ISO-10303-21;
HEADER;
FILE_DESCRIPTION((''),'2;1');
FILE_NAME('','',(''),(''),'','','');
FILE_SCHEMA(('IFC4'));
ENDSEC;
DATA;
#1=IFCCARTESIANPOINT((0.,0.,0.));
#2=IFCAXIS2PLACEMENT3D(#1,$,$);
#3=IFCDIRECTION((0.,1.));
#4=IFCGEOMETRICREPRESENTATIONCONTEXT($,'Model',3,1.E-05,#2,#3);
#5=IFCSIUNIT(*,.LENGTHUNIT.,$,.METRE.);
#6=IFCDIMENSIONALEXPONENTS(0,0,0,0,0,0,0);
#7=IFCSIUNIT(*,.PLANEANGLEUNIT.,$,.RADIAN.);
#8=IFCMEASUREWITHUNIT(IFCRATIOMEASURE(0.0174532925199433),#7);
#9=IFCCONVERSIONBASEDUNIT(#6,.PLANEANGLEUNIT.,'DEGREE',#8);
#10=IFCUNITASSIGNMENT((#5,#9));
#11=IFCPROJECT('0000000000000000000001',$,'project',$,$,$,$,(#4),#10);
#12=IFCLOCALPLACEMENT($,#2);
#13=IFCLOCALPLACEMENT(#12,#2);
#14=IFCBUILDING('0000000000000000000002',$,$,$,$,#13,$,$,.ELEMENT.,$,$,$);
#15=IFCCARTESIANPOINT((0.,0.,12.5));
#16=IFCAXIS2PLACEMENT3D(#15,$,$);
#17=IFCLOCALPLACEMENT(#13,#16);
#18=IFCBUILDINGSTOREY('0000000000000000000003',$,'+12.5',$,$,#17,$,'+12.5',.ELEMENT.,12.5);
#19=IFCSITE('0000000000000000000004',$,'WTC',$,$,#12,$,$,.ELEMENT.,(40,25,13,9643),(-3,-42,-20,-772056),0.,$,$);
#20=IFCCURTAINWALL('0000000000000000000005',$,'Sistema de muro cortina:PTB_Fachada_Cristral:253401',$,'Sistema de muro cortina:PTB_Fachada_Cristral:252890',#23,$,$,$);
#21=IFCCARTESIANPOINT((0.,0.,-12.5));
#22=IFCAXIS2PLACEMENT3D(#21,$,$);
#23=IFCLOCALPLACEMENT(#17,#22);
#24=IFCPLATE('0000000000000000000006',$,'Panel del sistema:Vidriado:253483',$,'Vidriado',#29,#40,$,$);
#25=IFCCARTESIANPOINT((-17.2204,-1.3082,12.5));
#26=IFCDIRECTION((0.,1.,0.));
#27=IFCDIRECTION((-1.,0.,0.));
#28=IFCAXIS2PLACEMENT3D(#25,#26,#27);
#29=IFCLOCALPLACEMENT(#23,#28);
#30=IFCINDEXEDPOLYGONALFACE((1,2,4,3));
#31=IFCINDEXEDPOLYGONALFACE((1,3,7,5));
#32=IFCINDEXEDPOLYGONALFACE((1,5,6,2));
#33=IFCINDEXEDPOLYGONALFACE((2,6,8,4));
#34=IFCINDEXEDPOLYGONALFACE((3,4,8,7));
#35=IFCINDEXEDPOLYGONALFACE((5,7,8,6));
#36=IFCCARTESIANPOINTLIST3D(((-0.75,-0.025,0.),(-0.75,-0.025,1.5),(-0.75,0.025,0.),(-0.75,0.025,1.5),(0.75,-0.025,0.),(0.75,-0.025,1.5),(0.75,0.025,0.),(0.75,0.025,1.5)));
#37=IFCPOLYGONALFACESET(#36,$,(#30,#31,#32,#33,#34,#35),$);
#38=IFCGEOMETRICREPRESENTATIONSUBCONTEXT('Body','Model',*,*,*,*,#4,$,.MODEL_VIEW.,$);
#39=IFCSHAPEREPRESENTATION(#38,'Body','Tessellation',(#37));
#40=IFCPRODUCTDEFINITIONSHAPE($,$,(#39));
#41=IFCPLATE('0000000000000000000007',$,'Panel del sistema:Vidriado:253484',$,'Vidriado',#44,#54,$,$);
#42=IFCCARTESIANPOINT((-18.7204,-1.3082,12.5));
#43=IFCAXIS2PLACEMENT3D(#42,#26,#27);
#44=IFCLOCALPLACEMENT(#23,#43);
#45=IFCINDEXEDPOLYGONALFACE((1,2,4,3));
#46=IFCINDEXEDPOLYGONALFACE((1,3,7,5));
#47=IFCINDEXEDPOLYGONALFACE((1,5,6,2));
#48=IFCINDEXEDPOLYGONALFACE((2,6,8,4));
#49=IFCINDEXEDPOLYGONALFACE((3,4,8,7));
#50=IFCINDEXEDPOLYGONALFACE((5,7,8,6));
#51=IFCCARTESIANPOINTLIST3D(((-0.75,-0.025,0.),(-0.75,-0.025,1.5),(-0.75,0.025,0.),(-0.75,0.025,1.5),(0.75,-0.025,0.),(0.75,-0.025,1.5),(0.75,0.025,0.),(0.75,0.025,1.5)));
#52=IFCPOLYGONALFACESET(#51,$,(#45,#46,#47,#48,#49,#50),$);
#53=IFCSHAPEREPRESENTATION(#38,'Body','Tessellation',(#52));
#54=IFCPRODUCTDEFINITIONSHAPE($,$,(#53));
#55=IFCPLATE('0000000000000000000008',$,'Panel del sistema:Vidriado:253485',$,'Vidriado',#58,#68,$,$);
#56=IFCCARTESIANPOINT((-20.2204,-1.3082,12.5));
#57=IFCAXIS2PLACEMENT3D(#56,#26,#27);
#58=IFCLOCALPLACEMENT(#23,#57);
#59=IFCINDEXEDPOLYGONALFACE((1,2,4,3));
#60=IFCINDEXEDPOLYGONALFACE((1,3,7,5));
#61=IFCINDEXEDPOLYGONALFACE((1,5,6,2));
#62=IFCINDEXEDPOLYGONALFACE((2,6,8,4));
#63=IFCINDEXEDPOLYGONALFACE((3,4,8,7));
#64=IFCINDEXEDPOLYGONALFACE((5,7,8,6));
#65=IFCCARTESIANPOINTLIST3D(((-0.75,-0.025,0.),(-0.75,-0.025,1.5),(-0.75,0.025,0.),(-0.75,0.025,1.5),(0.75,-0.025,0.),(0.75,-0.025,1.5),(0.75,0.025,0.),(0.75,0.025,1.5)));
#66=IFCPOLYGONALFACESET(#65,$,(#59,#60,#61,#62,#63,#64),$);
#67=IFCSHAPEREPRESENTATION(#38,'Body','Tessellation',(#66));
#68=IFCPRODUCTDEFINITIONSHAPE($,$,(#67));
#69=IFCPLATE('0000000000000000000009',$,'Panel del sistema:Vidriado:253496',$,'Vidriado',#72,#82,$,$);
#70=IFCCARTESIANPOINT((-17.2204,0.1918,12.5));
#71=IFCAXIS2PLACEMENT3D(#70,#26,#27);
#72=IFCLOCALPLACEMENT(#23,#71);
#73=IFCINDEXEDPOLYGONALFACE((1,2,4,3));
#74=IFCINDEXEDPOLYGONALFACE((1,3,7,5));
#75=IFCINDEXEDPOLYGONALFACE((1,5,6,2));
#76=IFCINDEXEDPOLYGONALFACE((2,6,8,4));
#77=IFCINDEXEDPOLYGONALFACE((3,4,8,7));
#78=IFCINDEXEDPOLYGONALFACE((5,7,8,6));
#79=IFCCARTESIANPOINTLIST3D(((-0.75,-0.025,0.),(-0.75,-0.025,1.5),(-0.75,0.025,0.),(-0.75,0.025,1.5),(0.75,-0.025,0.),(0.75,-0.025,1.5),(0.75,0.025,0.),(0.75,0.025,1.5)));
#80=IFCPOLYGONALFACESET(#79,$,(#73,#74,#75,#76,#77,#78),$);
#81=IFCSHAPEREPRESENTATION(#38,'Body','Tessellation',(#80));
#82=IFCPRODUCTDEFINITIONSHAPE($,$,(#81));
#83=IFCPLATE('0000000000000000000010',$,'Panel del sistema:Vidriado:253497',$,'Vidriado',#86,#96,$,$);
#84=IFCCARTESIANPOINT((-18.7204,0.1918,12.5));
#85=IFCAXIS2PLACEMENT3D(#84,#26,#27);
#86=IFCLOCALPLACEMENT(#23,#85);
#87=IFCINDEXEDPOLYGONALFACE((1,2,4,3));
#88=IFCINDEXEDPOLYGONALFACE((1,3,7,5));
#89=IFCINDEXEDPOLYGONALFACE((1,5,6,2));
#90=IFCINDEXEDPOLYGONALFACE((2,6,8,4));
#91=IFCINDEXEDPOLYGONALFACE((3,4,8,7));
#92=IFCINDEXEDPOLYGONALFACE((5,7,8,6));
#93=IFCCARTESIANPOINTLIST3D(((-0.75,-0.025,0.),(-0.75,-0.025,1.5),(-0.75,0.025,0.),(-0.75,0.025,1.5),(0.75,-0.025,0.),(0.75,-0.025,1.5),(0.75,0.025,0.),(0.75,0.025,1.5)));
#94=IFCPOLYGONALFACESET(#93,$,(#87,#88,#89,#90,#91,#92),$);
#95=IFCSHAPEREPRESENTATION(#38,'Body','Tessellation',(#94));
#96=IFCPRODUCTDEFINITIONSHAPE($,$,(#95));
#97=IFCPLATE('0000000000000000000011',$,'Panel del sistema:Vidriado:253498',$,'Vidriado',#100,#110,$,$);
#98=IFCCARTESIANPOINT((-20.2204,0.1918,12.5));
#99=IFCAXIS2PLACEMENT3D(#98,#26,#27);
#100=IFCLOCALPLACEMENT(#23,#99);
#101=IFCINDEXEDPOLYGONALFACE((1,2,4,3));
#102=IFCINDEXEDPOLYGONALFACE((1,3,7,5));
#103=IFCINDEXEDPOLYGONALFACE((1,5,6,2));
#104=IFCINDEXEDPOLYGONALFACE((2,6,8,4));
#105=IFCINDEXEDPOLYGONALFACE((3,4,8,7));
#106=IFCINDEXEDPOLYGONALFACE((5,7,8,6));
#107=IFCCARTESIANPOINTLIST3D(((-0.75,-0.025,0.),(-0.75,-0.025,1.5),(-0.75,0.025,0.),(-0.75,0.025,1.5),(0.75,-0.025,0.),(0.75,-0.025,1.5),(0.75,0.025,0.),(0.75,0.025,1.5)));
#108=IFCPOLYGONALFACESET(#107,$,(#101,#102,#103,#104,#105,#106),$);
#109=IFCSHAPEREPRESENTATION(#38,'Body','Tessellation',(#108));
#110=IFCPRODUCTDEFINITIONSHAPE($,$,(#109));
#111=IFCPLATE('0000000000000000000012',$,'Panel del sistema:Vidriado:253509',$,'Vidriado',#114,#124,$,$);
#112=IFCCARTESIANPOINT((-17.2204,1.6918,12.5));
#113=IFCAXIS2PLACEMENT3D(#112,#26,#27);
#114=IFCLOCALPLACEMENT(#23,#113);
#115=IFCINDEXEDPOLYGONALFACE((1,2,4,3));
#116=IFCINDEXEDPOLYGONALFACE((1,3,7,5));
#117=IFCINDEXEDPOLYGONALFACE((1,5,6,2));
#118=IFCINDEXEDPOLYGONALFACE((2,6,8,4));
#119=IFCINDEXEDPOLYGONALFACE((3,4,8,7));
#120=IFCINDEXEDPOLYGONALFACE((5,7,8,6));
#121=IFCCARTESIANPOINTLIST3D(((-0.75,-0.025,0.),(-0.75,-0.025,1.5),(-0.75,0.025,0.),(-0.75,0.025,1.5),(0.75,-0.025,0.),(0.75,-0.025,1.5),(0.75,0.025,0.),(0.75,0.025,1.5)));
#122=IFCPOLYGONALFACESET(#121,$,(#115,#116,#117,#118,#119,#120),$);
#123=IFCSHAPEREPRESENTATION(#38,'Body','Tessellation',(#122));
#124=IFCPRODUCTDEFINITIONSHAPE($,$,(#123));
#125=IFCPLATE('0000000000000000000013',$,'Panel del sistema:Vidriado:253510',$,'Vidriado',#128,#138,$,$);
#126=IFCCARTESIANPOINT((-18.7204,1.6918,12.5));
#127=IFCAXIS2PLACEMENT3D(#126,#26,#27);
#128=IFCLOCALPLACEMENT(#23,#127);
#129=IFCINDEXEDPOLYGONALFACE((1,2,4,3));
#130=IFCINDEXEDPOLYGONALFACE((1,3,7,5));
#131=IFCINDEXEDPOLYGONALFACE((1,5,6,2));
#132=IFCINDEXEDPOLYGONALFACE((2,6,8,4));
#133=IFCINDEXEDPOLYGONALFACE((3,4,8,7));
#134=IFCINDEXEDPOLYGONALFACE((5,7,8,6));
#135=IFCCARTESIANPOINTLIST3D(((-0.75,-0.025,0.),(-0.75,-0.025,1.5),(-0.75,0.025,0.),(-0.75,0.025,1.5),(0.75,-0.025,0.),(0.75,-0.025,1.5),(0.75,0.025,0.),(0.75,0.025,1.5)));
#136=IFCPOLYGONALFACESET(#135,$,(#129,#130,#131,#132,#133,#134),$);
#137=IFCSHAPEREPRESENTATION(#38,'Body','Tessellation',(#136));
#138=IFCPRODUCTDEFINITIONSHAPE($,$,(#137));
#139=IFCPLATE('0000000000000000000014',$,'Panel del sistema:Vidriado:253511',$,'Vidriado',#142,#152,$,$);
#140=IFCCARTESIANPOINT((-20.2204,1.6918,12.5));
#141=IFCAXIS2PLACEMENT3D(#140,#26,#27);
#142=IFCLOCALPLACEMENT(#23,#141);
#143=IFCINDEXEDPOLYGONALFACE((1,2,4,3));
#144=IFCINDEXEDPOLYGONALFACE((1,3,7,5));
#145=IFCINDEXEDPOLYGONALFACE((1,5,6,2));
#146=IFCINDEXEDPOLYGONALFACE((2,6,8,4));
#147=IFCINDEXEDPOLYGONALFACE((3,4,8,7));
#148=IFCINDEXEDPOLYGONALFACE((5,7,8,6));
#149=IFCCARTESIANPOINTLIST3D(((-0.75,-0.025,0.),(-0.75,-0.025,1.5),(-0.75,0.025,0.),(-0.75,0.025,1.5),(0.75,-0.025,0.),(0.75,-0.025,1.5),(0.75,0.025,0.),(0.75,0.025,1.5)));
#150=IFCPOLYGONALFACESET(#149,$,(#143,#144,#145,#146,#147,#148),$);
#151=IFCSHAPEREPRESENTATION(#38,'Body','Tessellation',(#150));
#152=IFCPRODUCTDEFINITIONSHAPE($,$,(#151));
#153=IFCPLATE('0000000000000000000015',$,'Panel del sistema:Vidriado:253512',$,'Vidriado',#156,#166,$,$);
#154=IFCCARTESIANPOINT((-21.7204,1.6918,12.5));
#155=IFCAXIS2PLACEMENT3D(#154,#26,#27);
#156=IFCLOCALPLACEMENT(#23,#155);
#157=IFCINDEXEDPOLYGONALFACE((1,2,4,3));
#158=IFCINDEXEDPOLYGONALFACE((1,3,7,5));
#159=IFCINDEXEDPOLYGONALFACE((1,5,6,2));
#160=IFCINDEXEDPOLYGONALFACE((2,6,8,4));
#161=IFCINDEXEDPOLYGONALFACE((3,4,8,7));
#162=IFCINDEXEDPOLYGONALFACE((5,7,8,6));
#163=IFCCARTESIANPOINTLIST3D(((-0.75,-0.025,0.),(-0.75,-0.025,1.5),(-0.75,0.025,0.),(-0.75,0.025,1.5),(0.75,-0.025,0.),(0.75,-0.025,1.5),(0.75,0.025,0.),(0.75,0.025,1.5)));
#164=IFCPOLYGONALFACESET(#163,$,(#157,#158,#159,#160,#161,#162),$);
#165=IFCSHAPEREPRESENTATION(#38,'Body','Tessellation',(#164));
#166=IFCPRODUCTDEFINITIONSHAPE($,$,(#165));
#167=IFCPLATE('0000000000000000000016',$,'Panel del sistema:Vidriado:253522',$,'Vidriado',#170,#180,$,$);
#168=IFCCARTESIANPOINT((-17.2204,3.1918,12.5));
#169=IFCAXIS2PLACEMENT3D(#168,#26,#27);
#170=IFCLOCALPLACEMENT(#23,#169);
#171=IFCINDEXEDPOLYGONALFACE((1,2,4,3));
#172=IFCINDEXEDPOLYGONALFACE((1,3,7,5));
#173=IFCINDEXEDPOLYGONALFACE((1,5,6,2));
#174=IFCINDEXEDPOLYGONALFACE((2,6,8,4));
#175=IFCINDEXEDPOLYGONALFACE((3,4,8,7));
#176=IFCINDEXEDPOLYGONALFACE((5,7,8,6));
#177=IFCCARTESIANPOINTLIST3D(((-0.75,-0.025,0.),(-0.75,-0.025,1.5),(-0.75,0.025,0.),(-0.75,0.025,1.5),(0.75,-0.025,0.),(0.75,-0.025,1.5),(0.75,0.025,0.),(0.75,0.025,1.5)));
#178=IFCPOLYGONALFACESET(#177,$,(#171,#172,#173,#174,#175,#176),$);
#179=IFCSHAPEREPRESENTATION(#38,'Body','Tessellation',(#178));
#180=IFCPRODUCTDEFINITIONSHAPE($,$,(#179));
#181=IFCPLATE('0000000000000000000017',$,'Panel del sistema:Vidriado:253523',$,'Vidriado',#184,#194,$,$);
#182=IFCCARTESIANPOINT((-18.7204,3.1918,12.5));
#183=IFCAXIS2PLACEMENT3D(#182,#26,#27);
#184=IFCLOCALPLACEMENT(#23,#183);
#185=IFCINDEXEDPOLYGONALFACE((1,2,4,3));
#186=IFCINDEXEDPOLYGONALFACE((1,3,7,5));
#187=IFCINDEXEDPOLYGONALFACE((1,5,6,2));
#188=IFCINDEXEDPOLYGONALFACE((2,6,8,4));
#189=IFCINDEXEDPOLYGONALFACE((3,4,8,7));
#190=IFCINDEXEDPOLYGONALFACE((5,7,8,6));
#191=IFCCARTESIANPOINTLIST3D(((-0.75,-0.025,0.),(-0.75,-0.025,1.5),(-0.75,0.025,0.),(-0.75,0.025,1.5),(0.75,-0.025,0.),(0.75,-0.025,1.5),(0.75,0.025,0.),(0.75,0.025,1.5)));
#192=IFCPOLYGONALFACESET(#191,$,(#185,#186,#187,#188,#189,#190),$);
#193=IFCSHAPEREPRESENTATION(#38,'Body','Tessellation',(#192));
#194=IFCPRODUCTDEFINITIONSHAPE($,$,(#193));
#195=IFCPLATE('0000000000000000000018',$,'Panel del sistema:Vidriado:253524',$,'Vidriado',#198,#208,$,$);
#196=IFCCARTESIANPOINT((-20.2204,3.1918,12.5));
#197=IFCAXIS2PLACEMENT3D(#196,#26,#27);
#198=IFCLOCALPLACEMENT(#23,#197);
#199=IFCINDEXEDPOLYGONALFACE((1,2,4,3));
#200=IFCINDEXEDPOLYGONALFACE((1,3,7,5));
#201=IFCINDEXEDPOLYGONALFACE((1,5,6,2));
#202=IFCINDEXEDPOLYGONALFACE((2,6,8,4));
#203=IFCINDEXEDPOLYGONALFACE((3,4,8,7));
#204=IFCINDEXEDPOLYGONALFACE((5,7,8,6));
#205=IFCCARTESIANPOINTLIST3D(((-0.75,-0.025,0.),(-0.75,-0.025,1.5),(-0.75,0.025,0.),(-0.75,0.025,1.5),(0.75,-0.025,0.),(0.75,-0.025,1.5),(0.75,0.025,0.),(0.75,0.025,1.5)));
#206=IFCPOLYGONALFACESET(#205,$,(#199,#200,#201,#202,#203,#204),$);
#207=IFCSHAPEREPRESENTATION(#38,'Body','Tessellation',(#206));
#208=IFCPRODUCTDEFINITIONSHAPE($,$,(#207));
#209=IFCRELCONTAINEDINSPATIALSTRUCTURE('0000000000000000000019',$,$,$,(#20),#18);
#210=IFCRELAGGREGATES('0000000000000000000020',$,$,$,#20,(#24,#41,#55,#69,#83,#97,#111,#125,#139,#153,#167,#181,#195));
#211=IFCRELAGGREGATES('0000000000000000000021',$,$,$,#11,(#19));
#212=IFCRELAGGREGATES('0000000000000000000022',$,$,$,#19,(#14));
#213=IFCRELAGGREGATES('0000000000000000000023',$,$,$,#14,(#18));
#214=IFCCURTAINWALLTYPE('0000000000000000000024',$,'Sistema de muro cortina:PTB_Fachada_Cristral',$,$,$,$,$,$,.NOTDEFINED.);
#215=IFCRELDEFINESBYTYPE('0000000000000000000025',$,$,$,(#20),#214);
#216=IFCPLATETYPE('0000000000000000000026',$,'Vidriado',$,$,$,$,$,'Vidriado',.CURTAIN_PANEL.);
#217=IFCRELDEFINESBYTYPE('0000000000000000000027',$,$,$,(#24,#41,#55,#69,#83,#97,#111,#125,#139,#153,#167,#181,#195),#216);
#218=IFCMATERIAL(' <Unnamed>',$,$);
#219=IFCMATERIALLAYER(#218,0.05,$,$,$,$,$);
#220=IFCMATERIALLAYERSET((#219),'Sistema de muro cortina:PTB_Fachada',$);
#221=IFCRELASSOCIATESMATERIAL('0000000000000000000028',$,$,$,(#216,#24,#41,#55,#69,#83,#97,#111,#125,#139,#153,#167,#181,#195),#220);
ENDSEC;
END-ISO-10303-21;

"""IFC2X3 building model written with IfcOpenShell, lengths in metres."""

from ifc_helpers import new_model, entity, si_unit, converted_unit, direction, frame, origin, origin_2d_with_axis, place, context, subcontext, project, spatial, rectangle, extrude, source, transform, mapped, material, layer, layer_set, layer_usage, type_object, type_shapes, element, aggregate, save


model = new_model("IFC2X3")

# Units and contexts
model_context = context("Model", 3, precision=1e-05, world=origin(), true_north=direction((0.0, 1.0)))
body_context = subcontext(model_context, "Body", "Model", "MODEL_VIEW")
ifc_project = project(units=[si_unit("LENGTHUNIT", "METRE"), converted_unit("PLANEANGLEUNIT", "DEGREE", entity("IfcRatioMeasure", 0.0174532925199433), si_unit("PLANEANGLEUNIT", "RADIAN"), dimensions=[0, 0, 0, 0, 0, 0, 0])], contexts=[model_context])

# Site, building, storey
site_placement = place(None, origin())
site = spatial("IfcSite", under=ifc_project, at=site_placement, Name="WTC", CompositionType="ELEMENT", RefLatitude=(40, 25, 13, 9643), RefLongitude=(-3, -42, -20, -772056), RefElevation=0.0)
building_placement = place(site_placement, origin())
building = spatial("IfcBuilding", under=site, at=building_placement, CompositionType="ELEMENT")
storey_placement = place(building_placement, frame((0.0, 0.0, 12.5)))
storey = spatial("IfcBuildingStorey", under=building, at=storey_placement, Name="+12.5", LongName="+12.5", CompositionType="ELEMENT", Elevation=12.5)

# Curtain wall, plates
curtain_wall_type = type_object("IfcCurtainWallType", Name="Sistema de muro cortina:PTB_Fachada_Cristral", PredefinedType="NOTDEFINED")
curtain_wall_placement = place(storey_placement, frame((0.0, 0.0, -12.5)))
curtain_wall = element("IfcCurtainWall", 1, at=curtain_wall_placement, inside=storey, type_object=curtain_wall_type, Name="Sistema de muro cortina:PTB_Fachada_Cristral:253401", ObjectType="Sistema de muro cortina:PTB_Fachada_Cristral:252890")
ifc_material = material(Name=" <Unnamed>")
ifc_layer = layer(ifc_material, 0.05)
ifc_layer_set = layer_set([ifc_layer], Name="Sistema de muro cortina:PTB_Fachada")
ifc_layer_usage_1 = layer_usage(ifc_layer_set, "AXIS3", "POSITIVE", 0.0)
plate_type_1 = type_object("IfcPlateType", Name="Vidriado", ElementType="Vidriado", PredefinedType="CURTAIN_PANEL", material=ifc_layer_set)
shared_shape_1 = source(origin(), body_context, "Body", "SweptSolid", [
    extrude(rectangle(XDim=0.05, YDim=1.5, at=origin_2d_with_axis()), frame((0.0, 0.0, 0.0), z_axis=(0.0, 0.0, 1.0), x_axis=(0.0, 1.0, 0.0)), (0.0, 0.0, 1.0), 1.5),
])
type_shapes(plate_type_1, [shared_shape_1])
plate_1_placement = place(curtain_wall_placement, frame((-17.2204, -1.3082, 12.5), z_axis=(0.0, 1.0, 0.0), x_axis=(-1.0, 0.0, 0.0)))
plate_1 = element("IfcPlate", 2, at=plate_1_placement, type_object=plate_type_1, material=ifc_layer_usage_1, Name="Panel del sistema:Vidriado:253483", ObjectType="Vidriado", context=body_context, shape_type="MappedRepresentation", body=[
    mapped(shared_shape_1, transform((0.0, 0.0, 0.0), scale=1.0)),
])
ifc_layer_usage_2 = layer_usage(ifc_layer_set, "AXIS3", "POSITIVE", 0.0)
plate_2_placement = place(curtain_wall_placement, frame((-18.7204, -1.3082, 12.5), z_axis=(0.0, 1.0, 0.0), x_axis=(-1.0, 0.0, 0.0)))
plate_2 = element("IfcPlate", 3, at=plate_2_placement, type_object=plate_type_1, material=ifc_layer_usage_2, Name="Panel del sistema:Vidriado:253484", ObjectType="Vidriado", context=body_context, shape_type="MappedRepresentation", body=[
    mapped(shared_shape_1, transform((0.0, 0.0, 0.0), scale=1.0)),
])
ifc_layer_usage_3 = layer_usage(ifc_layer_set, "AXIS3", "POSITIVE", 0.0)
plate_3_placement = place(curtain_wall_placement, frame((-20.2204, -1.3082, 12.5), z_axis=(0.0, 1.0, 0.0), x_axis=(-1.0, 0.0, 0.0)))
plate_3 = element("IfcPlate", 4, at=plate_3_placement, type_object=plate_type_1, material=ifc_layer_usage_3, Name="Panel del sistema:Vidriado:253485", ObjectType="Vidriado", context=body_context, shape_type="MappedRepresentation", body=[
    mapped(shared_shape_1, transform((0.0, 0.0, 0.0), scale=1.0)),
])
ifc_layer_usage_4 = layer_usage(ifc_layer_set, "AXIS3", "POSITIVE", 0.0)
plate_4_placement = place(curtain_wall_placement, frame((-17.2204, 0.1918, 12.5), z_axis=(0.0, 1.0, 0.0), x_axis=(-1.0, 0.0, 0.0)))
plate_4 = element("IfcPlate", 5, at=plate_4_placement, type_object=plate_type_1, material=ifc_layer_usage_4, Name="Panel del sistema:Vidriado:253496", ObjectType="Vidriado", context=body_context, shape_type="MappedRepresentation", body=[
    mapped(shared_shape_1, transform((0.0, 0.0, 0.0), scale=1.0)),
])
ifc_layer_usage_5 = layer_usage(ifc_layer_set, "AXIS3", "POSITIVE", 0.0)
plate_5_placement = place(curtain_wall_placement, frame((-18.7204, 0.1918, 12.5), z_axis=(0.0, 1.0, 0.0), x_axis=(-1.0, 0.0, 0.0)))
plate_5 = element("IfcPlate", 6, at=plate_5_placement, type_object=plate_type_1, material=ifc_layer_usage_5, Name="Panel del sistema:Vidriado:253497", ObjectType="Vidriado", context=body_context, shape_type="MappedRepresentation", body=[
    mapped(shared_shape_1, transform((0.0, 0.0, 0.0), scale=1.0)),
])
ifc_layer_usage_6 = layer_usage(ifc_layer_set, "AXIS3", "POSITIVE", 0.0)
plate_6_placement = place(curtain_wall_placement, frame((-20.2204, 0.1918, 12.5), z_axis=(0.0, 1.0, 0.0), x_axis=(-1.0, 0.0, 0.0)))
plate_6 = element("IfcPlate", 7, at=plate_6_placement, type_object=plate_type_1, material=ifc_layer_usage_6, Name="Panel del sistema:Vidriado:253498", ObjectType="Vidriado", context=body_context, shape_type="MappedRepresentation", body=[
    mapped(shared_shape_1, transform((0.0, 0.0, 0.0), scale=1.0)),
])
ifc_layer_usage_7 = layer_usage(ifc_layer_set, "AXIS3", "POSITIVE", 0.0)
plate_7_placement = place(curtain_wall_placement, frame((-17.2204, 1.6918, 12.5), z_axis=(0.0, 1.0, 0.0), x_axis=(-1.0, 0.0, 0.0)))
plate_7 = element("IfcPlate", 8, at=plate_7_placement, type_object=plate_type_1, material=ifc_layer_usage_7, Name="Panel del sistema:Vidriado:253509", ObjectType="Vidriado", context=body_context, shape_type="MappedRepresentation", body=[
    mapped(shared_shape_1, transform((0.0, 0.0, 0.0), scale=1.0)),
])
ifc_layer_usage_8 = layer_usage(ifc_layer_set, "AXIS3", "POSITIVE", 0.0)
plate_8_placement = place(curtain_wall_placement, frame((-18.7204, 1.6918, 12.5), z_axis=(0.0, 1.0, 0.0), x_axis=(-1.0, 0.0, 0.0)))
plate_8 = element("IfcPlate", 9, at=plate_8_placement, type_object=plate_type_1, material=ifc_layer_usage_8, Name="Panel del sistema:Vidriado:253510", ObjectType="Vidriado", context=body_context, shape_type="MappedRepresentation", body=[
    mapped(shared_shape_1, transform((0.0, 0.0, 0.0), scale=1.0)),
])
ifc_layer_usage_9 = layer_usage(ifc_layer_set, "AXIS3", "POSITIVE", 0.0)
plate_9_placement = place(curtain_wall_placement, frame((-20.2204, 1.6918, 12.5), z_axis=(0.0, 1.0, 0.0), x_axis=(-1.0, 0.0, 0.0)))
plate_9 = element("IfcPlate", 10, at=plate_9_placement, type_object=plate_type_1, material=ifc_layer_usage_9, Name="Panel del sistema:Vidriado:253511", ObjectType="Vidriado", context=body_context, shape_type="MappedRepresentation", body=[
    mapped(shared_shape_1, transform((0.0, 0.0, 0.0), scale=1.0)),
])
ifc_layer_usage_10 = layer_usage(ifc_layer_set, "AXIS3", "POSITIVE", 0.0)
plate_10_placement = place(curtain_wall_placement, frame((-21.7204, 1.6918, 12.5), z_axis=(0.0, 1.0, 0.0), x_axis=(-1.0, 0.0, 0.0)))
plate_10 = element("IfcPlate", 11, at=plate_10_placement, type_object=plate_type_1, material=ifc_layer_usage_10, Name="Panel del sistema:Vidriado:253512", ObjectType="Vidriado", context=body_context, shape_type="MappedRepresentation", body=[
    mapped(shared_shape_1, transform((0.0, 0.0, 0.0), scale=1.0)),
])
ifc_layer_usage_11 = layer_usage(ifc_layer_set, "AXIS3", "POSITIVE", 0.0)
plate_11_placement = place(curtain_wall_placement, frame((-17.2204, 3.1918, 12.5), z_axis=(0.0, 1.0, 0.0), x_axis=(-1.0, 0.0, 0.0)))
plate_11 = element("IfcPlate", 12, at=plate_11_placement, type_object=plate_type_1, material=ifc_layer_usage_11, Name="Panel del sistema:Vidriado:253522", ObjectType="Vidriado", context=body_context, shape_type="MappedRepresentation", body=[
    mapped(shared_shape_1, transform((0.0, 0.0, 0.0), scale=1.0)),
])
ifc_layer_usage_12 = layer_usage(ifc_layer_set, "AXIS3", "POSITIVE", 0.0)
plate_12_placement = place(curtain_wall_placement, frame((-18.7204, 3.1918, 12.5), z_axis=(0.0, 1.0, 0.0), x_axis=(-1.0, 0.0, 0.0)))
plate_12 = element("IfcPlate", 13, at=plate_12_placement, type_object=plate_type_1, material=ifc_layer_usage_12, Name="Panel del sistema:Vidriado:253523", ObjectType="Vidriado", context=body_context, shape_type="MappedRepresentation", body=[
    mapped(shared_shape_1, transform((0.0, 0.0, 0.0), scale=1.0)),
])
ifc_layer_usage_13 = layer_usage(ifc_layer_set, "AXIS3", "POSITIVE", 0.0)
plate_13_placement = place(curtain_wall_placement, frame((-20.2204, 3.1918, 12.5), z_axis=(0.0, 1.0, 0.0), x_axis=(-1.0, 0.0, 0.0)))
plate_13 = element("IfcPlate", 14, at=plate_13_placement, type_object=plate_type_1, material=ifc_layer_usage_13, Name="Panel del sistema:Vidriado:253524", ObjectType="Vidriado", context=body_context, shape_type="MappedRepresentation", body=[
    mapped(shared_shape_1, transform((0.0, 0.0, 0.0), scale=1.0)),
])
aggregate(curtain_wall, [plate_1, plate_2, plate_3, plate_4, plate_5, plate_6, plate_7, plate_8, plate_9, plate_10, plate_11, plate_12, plate_13])

save(model, "model.ifc")
